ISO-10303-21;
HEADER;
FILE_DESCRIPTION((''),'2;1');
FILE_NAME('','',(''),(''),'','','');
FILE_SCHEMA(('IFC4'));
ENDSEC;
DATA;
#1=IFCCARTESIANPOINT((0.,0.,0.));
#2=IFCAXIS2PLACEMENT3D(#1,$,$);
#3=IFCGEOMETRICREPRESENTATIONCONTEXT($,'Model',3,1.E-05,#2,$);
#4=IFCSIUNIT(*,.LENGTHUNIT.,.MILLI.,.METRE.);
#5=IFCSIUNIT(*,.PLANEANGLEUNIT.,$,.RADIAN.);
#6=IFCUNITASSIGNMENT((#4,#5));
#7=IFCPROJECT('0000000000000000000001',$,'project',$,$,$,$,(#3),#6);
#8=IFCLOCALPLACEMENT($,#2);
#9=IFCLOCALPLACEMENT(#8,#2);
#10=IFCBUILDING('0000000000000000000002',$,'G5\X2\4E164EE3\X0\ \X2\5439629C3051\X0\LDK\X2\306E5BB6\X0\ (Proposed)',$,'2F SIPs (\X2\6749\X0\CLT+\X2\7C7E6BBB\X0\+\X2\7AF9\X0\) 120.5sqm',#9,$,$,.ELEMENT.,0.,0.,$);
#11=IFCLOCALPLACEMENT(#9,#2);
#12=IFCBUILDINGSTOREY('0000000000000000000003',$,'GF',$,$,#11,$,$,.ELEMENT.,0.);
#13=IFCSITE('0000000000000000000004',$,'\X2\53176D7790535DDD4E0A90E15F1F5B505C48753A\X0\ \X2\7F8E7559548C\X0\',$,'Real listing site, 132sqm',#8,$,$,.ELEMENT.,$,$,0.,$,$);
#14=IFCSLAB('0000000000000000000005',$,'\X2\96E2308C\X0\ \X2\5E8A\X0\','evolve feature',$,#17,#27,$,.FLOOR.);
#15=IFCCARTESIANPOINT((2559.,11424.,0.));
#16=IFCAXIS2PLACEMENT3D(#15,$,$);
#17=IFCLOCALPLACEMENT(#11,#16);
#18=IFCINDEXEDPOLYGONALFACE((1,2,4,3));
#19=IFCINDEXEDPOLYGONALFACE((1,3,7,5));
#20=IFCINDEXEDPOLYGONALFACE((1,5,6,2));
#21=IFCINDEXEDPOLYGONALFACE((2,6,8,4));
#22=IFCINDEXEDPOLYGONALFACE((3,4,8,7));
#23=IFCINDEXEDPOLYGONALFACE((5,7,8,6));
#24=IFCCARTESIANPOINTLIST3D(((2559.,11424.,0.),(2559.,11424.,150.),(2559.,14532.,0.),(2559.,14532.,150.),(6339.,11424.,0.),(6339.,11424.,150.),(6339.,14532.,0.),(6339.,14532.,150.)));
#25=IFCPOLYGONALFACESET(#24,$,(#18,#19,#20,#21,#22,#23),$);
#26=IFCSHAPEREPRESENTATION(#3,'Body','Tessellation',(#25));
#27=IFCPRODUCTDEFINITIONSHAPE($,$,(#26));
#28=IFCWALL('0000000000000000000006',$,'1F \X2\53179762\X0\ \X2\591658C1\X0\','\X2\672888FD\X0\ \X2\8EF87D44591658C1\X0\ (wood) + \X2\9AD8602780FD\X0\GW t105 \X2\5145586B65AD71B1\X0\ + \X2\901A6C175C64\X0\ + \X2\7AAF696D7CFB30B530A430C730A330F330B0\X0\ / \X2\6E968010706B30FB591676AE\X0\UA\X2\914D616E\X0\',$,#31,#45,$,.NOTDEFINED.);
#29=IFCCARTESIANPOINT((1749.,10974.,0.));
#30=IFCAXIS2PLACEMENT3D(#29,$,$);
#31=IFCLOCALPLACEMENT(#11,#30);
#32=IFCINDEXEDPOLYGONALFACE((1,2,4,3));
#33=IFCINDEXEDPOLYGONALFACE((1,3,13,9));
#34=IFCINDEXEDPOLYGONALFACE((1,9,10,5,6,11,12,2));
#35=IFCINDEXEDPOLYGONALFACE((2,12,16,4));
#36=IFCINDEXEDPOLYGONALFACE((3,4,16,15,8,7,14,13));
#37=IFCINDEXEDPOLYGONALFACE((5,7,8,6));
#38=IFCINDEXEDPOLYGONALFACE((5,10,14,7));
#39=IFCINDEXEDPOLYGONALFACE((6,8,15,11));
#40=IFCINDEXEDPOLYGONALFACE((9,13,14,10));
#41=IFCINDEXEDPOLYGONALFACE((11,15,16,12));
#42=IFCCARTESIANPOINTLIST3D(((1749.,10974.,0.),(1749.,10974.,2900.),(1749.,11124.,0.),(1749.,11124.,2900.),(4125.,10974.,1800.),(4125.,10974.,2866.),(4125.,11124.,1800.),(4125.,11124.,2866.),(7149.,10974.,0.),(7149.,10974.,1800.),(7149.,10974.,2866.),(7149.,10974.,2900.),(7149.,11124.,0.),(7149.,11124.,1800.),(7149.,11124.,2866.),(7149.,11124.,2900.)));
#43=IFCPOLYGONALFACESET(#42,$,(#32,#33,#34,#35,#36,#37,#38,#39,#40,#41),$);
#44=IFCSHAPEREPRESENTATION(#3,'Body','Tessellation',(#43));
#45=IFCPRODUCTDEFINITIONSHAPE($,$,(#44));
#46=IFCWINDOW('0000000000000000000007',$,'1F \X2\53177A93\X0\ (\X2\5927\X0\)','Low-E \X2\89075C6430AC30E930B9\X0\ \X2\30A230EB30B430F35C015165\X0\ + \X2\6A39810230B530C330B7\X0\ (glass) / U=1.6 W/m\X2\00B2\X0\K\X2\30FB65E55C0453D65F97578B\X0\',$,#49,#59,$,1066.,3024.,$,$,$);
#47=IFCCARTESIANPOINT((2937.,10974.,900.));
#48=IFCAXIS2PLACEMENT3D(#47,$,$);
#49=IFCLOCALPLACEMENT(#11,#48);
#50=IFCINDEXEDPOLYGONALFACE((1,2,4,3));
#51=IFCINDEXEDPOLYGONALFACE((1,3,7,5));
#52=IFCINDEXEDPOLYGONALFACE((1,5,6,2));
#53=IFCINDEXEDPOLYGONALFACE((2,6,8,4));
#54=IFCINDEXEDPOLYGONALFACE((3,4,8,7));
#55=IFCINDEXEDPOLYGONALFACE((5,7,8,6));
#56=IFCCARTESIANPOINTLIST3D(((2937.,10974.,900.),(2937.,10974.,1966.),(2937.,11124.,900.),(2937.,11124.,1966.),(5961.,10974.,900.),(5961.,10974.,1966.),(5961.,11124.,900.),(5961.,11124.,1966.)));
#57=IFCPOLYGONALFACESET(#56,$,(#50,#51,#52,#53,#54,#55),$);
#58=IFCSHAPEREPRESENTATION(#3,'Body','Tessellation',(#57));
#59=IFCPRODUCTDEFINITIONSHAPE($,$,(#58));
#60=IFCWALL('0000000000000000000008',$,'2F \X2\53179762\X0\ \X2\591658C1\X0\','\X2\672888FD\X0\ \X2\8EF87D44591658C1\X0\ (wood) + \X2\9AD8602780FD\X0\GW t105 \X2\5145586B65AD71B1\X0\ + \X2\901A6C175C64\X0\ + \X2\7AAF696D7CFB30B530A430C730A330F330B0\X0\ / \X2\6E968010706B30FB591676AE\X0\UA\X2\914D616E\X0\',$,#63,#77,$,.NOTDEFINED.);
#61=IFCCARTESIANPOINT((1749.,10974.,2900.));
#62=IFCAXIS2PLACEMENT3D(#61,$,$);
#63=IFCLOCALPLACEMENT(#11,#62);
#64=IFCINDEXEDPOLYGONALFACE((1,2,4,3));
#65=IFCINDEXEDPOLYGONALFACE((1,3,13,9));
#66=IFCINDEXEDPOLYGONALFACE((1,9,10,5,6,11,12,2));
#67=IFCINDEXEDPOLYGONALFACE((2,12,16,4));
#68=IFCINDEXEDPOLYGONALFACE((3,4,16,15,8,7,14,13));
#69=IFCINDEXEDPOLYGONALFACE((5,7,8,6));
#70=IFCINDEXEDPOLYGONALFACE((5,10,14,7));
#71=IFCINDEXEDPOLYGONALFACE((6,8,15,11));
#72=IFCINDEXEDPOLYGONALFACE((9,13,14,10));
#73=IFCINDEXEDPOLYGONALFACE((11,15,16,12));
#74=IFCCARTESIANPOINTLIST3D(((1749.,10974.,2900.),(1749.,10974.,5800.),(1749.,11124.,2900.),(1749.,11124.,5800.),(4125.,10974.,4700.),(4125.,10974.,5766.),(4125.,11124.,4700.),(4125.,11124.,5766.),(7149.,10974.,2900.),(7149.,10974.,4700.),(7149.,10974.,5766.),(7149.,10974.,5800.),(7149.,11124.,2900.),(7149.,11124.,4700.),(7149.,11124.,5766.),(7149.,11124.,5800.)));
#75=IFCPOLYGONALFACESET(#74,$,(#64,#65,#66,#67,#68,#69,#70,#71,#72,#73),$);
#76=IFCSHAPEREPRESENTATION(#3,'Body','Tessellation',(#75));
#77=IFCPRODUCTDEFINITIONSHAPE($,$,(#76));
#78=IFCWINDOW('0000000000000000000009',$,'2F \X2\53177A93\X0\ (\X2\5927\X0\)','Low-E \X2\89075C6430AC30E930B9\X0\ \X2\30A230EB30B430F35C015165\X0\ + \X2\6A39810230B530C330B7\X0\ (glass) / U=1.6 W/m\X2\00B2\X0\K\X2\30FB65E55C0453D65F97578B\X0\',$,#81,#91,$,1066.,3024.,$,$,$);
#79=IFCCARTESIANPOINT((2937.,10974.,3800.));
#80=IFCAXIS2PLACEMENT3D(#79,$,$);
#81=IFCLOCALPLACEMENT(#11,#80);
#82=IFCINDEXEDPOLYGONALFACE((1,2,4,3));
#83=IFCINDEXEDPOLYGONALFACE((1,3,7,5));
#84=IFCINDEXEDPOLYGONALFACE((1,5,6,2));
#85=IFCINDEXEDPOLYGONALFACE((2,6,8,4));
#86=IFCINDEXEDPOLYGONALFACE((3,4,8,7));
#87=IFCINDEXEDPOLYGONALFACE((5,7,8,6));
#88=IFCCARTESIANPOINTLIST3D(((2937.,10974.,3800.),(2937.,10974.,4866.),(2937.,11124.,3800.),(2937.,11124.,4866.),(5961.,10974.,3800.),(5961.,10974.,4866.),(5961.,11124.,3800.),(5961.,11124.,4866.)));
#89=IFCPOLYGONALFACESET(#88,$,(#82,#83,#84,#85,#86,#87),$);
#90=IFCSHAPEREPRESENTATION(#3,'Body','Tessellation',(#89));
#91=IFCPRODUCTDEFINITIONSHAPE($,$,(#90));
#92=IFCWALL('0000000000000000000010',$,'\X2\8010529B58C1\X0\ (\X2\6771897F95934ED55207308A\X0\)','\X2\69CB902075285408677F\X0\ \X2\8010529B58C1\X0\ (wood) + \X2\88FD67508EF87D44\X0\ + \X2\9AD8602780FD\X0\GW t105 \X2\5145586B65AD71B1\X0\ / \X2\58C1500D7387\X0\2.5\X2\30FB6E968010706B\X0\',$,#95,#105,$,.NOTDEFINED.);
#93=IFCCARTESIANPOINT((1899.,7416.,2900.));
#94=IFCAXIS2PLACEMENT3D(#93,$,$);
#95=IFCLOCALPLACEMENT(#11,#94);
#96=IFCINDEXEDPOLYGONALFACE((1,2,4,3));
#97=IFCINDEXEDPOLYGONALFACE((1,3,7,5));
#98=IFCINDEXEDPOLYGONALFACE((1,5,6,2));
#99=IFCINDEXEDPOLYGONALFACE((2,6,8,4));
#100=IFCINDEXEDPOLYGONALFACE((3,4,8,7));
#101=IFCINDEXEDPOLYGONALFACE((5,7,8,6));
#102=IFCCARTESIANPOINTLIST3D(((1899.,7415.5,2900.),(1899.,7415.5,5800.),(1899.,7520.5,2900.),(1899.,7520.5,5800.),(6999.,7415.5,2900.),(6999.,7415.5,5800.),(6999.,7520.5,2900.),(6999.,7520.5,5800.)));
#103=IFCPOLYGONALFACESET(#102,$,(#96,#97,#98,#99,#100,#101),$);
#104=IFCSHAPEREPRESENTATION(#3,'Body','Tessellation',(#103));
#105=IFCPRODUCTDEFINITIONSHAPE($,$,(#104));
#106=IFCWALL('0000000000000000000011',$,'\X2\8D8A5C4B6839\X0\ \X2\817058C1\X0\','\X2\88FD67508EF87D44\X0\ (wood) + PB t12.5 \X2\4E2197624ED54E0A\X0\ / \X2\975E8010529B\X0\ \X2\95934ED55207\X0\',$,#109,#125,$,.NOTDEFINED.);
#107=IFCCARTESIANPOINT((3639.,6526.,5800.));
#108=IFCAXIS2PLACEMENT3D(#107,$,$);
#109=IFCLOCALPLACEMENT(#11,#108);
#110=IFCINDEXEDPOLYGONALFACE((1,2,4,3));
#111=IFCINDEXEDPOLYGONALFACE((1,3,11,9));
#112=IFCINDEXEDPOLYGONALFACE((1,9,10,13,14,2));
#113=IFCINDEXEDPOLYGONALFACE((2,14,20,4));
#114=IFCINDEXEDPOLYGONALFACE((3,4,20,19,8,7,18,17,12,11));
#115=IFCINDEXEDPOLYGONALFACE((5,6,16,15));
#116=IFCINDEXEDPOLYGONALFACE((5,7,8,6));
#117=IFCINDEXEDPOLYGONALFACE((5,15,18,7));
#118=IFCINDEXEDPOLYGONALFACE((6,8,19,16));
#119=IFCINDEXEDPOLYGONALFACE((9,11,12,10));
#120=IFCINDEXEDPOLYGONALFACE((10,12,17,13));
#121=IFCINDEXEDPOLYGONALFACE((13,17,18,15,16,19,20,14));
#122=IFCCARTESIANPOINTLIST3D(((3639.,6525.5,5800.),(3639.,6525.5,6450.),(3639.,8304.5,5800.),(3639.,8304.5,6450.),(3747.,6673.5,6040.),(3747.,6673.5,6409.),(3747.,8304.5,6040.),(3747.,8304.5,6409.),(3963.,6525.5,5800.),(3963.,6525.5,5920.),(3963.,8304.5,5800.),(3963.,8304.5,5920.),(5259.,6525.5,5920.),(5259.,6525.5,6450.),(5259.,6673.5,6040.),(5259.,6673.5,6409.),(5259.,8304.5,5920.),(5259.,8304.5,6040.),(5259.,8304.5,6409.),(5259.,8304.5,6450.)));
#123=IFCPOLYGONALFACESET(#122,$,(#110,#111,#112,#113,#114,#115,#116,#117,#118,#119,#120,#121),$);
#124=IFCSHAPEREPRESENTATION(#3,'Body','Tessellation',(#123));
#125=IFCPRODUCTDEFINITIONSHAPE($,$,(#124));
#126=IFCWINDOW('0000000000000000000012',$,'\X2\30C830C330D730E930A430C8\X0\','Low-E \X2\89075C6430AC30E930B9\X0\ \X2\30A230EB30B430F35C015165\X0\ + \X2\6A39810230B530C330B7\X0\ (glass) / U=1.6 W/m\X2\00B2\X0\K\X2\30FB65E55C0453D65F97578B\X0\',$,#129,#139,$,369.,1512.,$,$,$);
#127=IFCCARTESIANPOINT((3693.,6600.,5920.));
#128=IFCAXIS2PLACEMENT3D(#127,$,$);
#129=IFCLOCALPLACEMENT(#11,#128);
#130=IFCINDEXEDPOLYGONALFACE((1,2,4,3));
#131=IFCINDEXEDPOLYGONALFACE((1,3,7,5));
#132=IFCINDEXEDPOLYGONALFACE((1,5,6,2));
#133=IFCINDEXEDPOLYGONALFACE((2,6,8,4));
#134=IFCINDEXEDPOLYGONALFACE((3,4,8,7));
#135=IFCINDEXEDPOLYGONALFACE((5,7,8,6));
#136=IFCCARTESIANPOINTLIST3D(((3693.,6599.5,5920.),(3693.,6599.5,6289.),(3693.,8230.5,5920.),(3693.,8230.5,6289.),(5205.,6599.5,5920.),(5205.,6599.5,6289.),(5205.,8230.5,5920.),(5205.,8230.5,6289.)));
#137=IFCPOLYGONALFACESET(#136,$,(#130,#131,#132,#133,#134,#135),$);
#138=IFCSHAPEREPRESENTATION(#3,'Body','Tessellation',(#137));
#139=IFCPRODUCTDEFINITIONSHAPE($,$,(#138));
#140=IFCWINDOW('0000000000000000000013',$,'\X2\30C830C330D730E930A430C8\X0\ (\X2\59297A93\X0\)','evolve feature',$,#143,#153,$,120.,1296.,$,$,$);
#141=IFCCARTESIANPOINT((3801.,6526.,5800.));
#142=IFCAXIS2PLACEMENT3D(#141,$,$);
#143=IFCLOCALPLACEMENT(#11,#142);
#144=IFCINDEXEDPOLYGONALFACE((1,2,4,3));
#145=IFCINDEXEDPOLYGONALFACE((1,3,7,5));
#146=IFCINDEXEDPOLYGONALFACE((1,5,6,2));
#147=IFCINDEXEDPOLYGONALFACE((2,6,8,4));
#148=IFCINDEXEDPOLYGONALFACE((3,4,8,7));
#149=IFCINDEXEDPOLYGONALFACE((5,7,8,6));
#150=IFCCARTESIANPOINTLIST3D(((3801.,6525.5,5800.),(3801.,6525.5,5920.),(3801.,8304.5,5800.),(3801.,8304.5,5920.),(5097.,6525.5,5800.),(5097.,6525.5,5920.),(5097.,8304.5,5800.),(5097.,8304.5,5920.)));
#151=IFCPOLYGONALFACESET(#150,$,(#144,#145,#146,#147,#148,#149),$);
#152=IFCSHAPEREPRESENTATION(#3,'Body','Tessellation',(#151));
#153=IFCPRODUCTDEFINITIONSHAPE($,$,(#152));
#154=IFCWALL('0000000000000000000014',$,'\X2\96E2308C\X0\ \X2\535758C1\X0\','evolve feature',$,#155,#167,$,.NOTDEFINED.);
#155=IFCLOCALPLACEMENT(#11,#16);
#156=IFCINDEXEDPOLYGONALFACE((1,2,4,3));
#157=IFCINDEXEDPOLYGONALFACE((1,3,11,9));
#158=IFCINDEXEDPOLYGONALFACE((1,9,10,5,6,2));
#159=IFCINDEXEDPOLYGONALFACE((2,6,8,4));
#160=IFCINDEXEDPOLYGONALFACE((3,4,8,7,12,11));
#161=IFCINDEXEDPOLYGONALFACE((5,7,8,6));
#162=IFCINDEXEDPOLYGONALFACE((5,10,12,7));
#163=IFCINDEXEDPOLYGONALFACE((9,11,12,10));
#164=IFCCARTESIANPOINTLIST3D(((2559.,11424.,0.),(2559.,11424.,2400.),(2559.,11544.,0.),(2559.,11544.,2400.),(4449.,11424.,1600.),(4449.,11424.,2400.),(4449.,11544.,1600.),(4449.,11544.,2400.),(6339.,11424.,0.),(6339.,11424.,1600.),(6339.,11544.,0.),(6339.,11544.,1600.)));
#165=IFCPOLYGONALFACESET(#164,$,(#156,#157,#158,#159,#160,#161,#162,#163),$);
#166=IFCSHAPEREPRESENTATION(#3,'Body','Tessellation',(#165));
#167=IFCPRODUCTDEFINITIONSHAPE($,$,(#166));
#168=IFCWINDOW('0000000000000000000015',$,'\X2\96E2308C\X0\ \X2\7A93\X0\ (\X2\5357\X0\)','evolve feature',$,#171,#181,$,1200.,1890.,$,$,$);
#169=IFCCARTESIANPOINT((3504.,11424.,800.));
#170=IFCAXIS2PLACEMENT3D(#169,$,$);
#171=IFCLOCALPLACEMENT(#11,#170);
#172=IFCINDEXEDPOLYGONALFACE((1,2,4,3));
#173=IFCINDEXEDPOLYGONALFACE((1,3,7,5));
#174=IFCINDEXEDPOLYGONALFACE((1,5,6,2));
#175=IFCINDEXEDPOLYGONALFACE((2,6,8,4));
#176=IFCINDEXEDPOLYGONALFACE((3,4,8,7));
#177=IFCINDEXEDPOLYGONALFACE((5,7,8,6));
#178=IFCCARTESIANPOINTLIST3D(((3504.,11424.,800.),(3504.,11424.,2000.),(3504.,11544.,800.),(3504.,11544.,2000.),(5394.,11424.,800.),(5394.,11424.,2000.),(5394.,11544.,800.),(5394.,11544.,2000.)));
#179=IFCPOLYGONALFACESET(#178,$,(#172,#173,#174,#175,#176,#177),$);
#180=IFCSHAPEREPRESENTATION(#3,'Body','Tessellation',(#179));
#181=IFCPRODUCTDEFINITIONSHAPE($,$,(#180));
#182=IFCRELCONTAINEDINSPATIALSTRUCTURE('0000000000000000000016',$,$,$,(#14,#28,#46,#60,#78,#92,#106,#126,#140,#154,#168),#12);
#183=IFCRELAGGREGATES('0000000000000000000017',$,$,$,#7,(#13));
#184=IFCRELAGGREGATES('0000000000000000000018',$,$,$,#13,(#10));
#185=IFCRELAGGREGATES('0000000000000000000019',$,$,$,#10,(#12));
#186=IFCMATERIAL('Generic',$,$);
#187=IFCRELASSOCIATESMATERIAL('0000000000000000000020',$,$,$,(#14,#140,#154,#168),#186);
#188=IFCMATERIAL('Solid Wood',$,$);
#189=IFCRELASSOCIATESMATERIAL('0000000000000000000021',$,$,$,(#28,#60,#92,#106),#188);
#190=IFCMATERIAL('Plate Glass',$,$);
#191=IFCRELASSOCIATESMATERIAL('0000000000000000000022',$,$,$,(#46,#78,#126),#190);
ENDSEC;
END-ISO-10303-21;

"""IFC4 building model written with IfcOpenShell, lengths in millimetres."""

from ifc_helpers import new_model, si_unit, frame, frame_2d, origin, place, context, project, spatial, rectangle, extrude, material, element, fill, save


model = new_model("IFC4")

# Units and contexts
model_context = context("Model", 3, precision=1e-05, world=origin())
ifc_project = project(units=[si_unit("LENGTHUNIT", "METRE", prefix="MILLI"), si_unit("PLANEANGLEUNIT", "RADIAN")], contexts=[model_context])

# Site, building, storey
site_placement = place(None, origin())
site = spatial("IfcSite", under=ifc_project, at=site_placement, Name="北海道川上郡弟子屈町 美留和", ObjectType="Real listing site, 132sqm", CompositionType="ELEMENT", RefElevation=0.0)
building_placement = place(site_placement, origin())
building = spatial("IfcBuilding", under=site, at=building_placement, Name="G5世代 吹抜けLDKの家 (Proposed)", ObjectType="2F SIPs (杉CLT+籾殻+竹) 120.5sqm", CompositionType="ELEMENT", ElevationOfRefHeight=0.0, ElevationOfTerrain=0.0)
storey_placement = place(building_placement, origin())
storey = spatial("IfcBuildingStorey", under=building, at=storey_placement, Name="GF", CompositionType="ELEMENT", Elevation=0.0)

# Slab
ifc_material_1 = material(Name="Generic")
slab_placement = place(storey_placement, frame((2559.0, 11424.0, 0.0)))
element("IfcSlab", 1, at=slab_placement, inside=storey, material=ifc_material_1, Name="離れ 床", Description="evolve feature", PredefinedType="FLOOR", context=model_context, shape_type="SweptSolid", body=[
    extrude(rectangle(XDim=3780.0, YDim=3108.0, at=frame_2d((1890.0, 1554.0))), frame((2559.0, 11424.0, 0.0)), (0.0, 0.0, 1.0), 150.0),
])

# Wall, opening, window
ifc_material_2 = material(Name="Solid Wood")
wall_1_placement = place(storey_placement, frame((1749.0, 10974.0, 0.0)))
wall_1 = element("IfcWall", 2, at=wall_1_placement, inside=storey, material=ifc_material_2, Name="1F 北面 外壁", Description="木製 軸組外壁 (wood) + 高性能GW t105 充填断熱 + 通気層 + 窯業系サイディング / 準耐火・外皮UA配慮", PredefinedType="NOTDEFINED", context=model_context, shape_type="SweptSolid", body=[
    extrude(rectangle(XDim=5400.0, YDim=150.0, at=frame_2d((2700.0, 75.0))), frame((1749.0, 10974.0, 0.0)), (0.0, 0.0, 1.0), 2900.0),
])
opening_1_placement = place(storey_placement, frame((2937.0, 10974.0, 900.0)))
opening_1 = element("IfcOpeningElement", 3, at=opening_1_placement, cuts=wall_1, PredefinedType="NOTDEFINED", context=model_context, shape_type="SweptSolid", body=[
    extrude(rectangle(XDim=3024.0, YDim=150.0, at=frame_2d((1512.0, 75.0))), frame((2937.0, 10974.0, 900.0)), (0.0, 0.0, 1.0), 1066.0),
])
ifc_material_3 = material(Name="Plate Glass")
window_1_placement = place(storey_placement, frame((2937.0, 10974.0, 900.0)))
window_1 = element("IfcWindow", 4, at=window_1_placement, inside=storey, material=ifc_material_3, Name="1F 北窓 (大)", Description="Low-E 複層ガラス アルゴン封入 + 樹脂サッシ (glass) / U=1.6 W/m²K・日射取得型", OverallHeight=1066.0, OverallWidth=3024.0, context=model_context, shape_type="SweptSolid", body=[
    extrude(rectangle(XDim=3024.0, YDim=150.0, at=frame_2d((1512.0, 75.0))), frame((2937.0, 10974.0, 900.0)), (0.0, 0.0, 1.0), 1066.0),
])
fill(opening_1, window_1)

# Wall, opening, window
wall_2_placement = place(storey_placement, frame((1749.0, 10974.0, 2900.0)))
wall_2 = element("IfcWall", 5, at=wall_2_placement, inside=storey, material=ifc_material_2, Name="2F 北面 外壁", Description="木製 軸組外壁 (wood) + 高性能GW t105 充填断熱 + 通気層 + 窯業系サイディング / 準耐火・外皮UA配慮", PredefinedType="NOTDEFINED", context=model_context, shape_type="SweptSolid", body=[
    extrude(rectangle(XDim=5400.0, YDim=150.0, at=frame_2d((2700.0, 75.0))), frame((1749.0, 10974.0, 2900.0)), (0.0, 0.0, 1.0), 2900.0),
])
opening_2_placement = place(storey_placement, frame((2937.0, 10974.0, 3800.0)))
opening_2 = element("IfcOpeningElement", 6, at=opening_2_placement, cuts=wall_2, PredefinedType="NOTDEFINED", context=model_context, shape_type="SweptSolid", body=[
    extrude(rectangle(XDim=3024.0, YDim=150.0, at=frame_2d((1512.0, 75.0))), frame((2937.0, 10974.0, 3800.0)), (0.0, 0.0, 1.0), 1066.0),
])
window_2_placement = place(storey_placement, frame((2937.0, 10974.0, 3800.0)))
window_2 = element("IfcWindow", 7, at=window_2_placement, inside=storey, material=ifc_material_3, Name="2F 北窓 (大)", Description="Low-E 複層ガラス アルゴン封入 + 樹脂サッシ (glass) / U=1.6 W/m²K・日射取得型", OverallHeight=1066.0, OverallWidth=3024.0, context=model_context, shape_type="SweptSolid", body=[
    extrude(rectangle(XDim=3024.0, YDim=150.0, at=frame_2d((1512.0, 75.0))), frame((2937.0, 10974.0, 3800.0)), (0.0, 0.0, 1.0), 1066.0),
])
fill(opening_2, window_2)

# Wall
wall_3_placement = place(storey_placement, frame((1899.0, 7416.0, 2900.0)))
element("IfcWall", 8, at=wall_3_placement, inside=storey, material=ifc_material_2, Name="耐力壁 (東西間仕切り)", Description="構造用合板 耐力壁 (wood) + 製材軸組 + 高性能GW t105 充填断熱 / 壁倍率2.5・準耐火", PredefinedType="NOTDEFINED", context=model_context, shape_type="SweptSolid", body=[
    extrude(rectangle(XDim=5100.0, YDim=105.0, at=frame_2d((2550.0, 52.0))), frame((1899.0, 7416.0, 2900.0)), (0.0, 0.0, 1.0), 2900.0),
])

# Wall, openings, windows
wall_4_placement = place(storey_placement, frame((3639.0, 6526.0, 5800.0)))
wall_4 = element("IfcWall", 9, at=wall_4_placement, inside=storey, material=ifc_material_2, Name="越屋根 腰壁", Description="製材軸組 (wood) + PB t12.5 両面仕上 / 非耐力 間仕切", PredefinedType="NOTDEFINED", context=model_context, shape_type="SweptSolid", body=[
    extrude(rectangle(XDim=1620.0, YDim=1779.0, at=frame_2d((810.0, 889.0))), frame((3639.0, 6526.0, 5800.0)), (0.0, 0.0, 1.0), 650.0),
])
opening_3_placement = place(storey_placement, frame((3693.0, 6600.0, 5920.0)))
opening_3 = element("IfcOpeningElement", 10, at=opening_3_placement, cuts=wall_4, PredefinedType="NOTDEFINED", context=model_context, shape_type="SweptSolid", body=[
    extrude(rectangle(XDim=1512.0, YDim=1631.0, at=frame_2d((756.0, 815.0))), frame((3693.0, 6600.0, 5920.0)), (0.0, 0.0, 1.0), 369.0),
])
opening_4_placement = place(storey_placement, frame((3801.0, 6526.0, 5800.0)))
opening_4 = element("IfcOpeningElement", 11, at=opening_4_placement, cuts=wall_4, PredefinedType="NOTDEFINED", context=model_context, shape_type="SweptSolid", body=[
    extrude(rectangle(XDim=1296.0, YDim=1779.0, at=frame_2d((648.0, 889.0))), frame((3801.0, 6526.0, 5800.0)), (0.0, 0.0, 1.0), 120.0),
])
window_3_placement = place(storey_placement, frame((3693.0, 6600.0, 5920.0)))
window_3 = element("IfcWindow", 12, at=window_3_placement, inside=storey, material=ifc_material_3, Name="トップライト", Description="Low-E 複層ガラス アルゴン封入 + 樹脂サッシ (glass) / U=1.6 W/m²K・日射取得型", OverallHeight=369.0, OverallWidth=1512.0, context=model_context, shape_type="SweptSolid", body=[
    extrude(rectangle(XDim=1512.0, YDim=1631.0, at=frame_2d((756.0, 815.0))), frame((3693.0, 6600.0, 5920.0)), (0.0, 0.0, 1.0), 369.0),
])
fill(opening_3, window_3)
window_4_placement = place(storey_placement, frame((3801.0, 6526.0, 5800.0)))
window_4 = element("IfcWindow", 13, at=window_4_placement, inside=storey, material=ifc_material_1, Name="トップライト (天窓)", Description="evolve feature", OverallHeight=120.0, OverallWidth=1296.0, context=model_context, shape_type="SweptSolid", body=[
    extrude(rectangle(XDim=1296.0, YDim=1779.0, at=frame_2d((648.0, 889.0))), frame((3801.0, 6526.0, 5800.0)), (0.0, 0.0, 1.0), 120.0),
])
fill(opening_4, window_4)

# Wall, opening, window
wall_5_placement = place(storey_placement, frame((2559.0, 11424.0, 0.0)))
wall_5 = element("IfcWall", 14, at=wall_5_placement, inside=storey, material=ifc_material_1, Name="離れ 南壁", Description="evolve feature", PredefinedType="NOTDEFINED", context=model_context, shape_type="SweptSolid", body=[
    extrude(rectangle(XDim=3780.0, YDim=120.0, at=frame_2d((1890.0, 60.0))), frame((2559.0, 11424.0, 0.0)), (0.0, 0.0, 1.0), 2400.0),
])
opening_5_placement = place(storey_placement, frame((3504.0, 11424.0, 800.0)))
opening_5 = element("IfcOpeningElement", 15, at=opening_5_placement, cuts=wall_5, PredefinedType="NOTDEFINED", context=model_context, shape_type="SweptSolid", body=[
    extrude(rectangle(XDim=1890.0, YDim=120.0, at=frame_2d((945.0, 60.0))), frame((3504.0, 11424.0, 800.0)), (0.0, 0.0, 1.0), 1200.0),
])
window_5_placement = place(storey_placement, frame((3504.0, 11424.0, 800.0)))
window_5 = element("IfcWindow", 16, at=window_5_placement, inside=storey, material=ifc_material_1, Name="離れ 窓 (南)", Description="evolve feature", OverallHeight=1200.0, OverallWidth=1890.0, context=model_context, shape_type="SweptSolid", body=[
    extrude(rectangle(XDim=1890.0, YDim=120.0, at=frame_2d((945.0, 60.0))), frame((3504.0, 11424.0, 800.0)), (0.0, 0.0, 1.0), 1200.0),
])
fill(opening_5, window_5)

save(model, "model.ifc")
